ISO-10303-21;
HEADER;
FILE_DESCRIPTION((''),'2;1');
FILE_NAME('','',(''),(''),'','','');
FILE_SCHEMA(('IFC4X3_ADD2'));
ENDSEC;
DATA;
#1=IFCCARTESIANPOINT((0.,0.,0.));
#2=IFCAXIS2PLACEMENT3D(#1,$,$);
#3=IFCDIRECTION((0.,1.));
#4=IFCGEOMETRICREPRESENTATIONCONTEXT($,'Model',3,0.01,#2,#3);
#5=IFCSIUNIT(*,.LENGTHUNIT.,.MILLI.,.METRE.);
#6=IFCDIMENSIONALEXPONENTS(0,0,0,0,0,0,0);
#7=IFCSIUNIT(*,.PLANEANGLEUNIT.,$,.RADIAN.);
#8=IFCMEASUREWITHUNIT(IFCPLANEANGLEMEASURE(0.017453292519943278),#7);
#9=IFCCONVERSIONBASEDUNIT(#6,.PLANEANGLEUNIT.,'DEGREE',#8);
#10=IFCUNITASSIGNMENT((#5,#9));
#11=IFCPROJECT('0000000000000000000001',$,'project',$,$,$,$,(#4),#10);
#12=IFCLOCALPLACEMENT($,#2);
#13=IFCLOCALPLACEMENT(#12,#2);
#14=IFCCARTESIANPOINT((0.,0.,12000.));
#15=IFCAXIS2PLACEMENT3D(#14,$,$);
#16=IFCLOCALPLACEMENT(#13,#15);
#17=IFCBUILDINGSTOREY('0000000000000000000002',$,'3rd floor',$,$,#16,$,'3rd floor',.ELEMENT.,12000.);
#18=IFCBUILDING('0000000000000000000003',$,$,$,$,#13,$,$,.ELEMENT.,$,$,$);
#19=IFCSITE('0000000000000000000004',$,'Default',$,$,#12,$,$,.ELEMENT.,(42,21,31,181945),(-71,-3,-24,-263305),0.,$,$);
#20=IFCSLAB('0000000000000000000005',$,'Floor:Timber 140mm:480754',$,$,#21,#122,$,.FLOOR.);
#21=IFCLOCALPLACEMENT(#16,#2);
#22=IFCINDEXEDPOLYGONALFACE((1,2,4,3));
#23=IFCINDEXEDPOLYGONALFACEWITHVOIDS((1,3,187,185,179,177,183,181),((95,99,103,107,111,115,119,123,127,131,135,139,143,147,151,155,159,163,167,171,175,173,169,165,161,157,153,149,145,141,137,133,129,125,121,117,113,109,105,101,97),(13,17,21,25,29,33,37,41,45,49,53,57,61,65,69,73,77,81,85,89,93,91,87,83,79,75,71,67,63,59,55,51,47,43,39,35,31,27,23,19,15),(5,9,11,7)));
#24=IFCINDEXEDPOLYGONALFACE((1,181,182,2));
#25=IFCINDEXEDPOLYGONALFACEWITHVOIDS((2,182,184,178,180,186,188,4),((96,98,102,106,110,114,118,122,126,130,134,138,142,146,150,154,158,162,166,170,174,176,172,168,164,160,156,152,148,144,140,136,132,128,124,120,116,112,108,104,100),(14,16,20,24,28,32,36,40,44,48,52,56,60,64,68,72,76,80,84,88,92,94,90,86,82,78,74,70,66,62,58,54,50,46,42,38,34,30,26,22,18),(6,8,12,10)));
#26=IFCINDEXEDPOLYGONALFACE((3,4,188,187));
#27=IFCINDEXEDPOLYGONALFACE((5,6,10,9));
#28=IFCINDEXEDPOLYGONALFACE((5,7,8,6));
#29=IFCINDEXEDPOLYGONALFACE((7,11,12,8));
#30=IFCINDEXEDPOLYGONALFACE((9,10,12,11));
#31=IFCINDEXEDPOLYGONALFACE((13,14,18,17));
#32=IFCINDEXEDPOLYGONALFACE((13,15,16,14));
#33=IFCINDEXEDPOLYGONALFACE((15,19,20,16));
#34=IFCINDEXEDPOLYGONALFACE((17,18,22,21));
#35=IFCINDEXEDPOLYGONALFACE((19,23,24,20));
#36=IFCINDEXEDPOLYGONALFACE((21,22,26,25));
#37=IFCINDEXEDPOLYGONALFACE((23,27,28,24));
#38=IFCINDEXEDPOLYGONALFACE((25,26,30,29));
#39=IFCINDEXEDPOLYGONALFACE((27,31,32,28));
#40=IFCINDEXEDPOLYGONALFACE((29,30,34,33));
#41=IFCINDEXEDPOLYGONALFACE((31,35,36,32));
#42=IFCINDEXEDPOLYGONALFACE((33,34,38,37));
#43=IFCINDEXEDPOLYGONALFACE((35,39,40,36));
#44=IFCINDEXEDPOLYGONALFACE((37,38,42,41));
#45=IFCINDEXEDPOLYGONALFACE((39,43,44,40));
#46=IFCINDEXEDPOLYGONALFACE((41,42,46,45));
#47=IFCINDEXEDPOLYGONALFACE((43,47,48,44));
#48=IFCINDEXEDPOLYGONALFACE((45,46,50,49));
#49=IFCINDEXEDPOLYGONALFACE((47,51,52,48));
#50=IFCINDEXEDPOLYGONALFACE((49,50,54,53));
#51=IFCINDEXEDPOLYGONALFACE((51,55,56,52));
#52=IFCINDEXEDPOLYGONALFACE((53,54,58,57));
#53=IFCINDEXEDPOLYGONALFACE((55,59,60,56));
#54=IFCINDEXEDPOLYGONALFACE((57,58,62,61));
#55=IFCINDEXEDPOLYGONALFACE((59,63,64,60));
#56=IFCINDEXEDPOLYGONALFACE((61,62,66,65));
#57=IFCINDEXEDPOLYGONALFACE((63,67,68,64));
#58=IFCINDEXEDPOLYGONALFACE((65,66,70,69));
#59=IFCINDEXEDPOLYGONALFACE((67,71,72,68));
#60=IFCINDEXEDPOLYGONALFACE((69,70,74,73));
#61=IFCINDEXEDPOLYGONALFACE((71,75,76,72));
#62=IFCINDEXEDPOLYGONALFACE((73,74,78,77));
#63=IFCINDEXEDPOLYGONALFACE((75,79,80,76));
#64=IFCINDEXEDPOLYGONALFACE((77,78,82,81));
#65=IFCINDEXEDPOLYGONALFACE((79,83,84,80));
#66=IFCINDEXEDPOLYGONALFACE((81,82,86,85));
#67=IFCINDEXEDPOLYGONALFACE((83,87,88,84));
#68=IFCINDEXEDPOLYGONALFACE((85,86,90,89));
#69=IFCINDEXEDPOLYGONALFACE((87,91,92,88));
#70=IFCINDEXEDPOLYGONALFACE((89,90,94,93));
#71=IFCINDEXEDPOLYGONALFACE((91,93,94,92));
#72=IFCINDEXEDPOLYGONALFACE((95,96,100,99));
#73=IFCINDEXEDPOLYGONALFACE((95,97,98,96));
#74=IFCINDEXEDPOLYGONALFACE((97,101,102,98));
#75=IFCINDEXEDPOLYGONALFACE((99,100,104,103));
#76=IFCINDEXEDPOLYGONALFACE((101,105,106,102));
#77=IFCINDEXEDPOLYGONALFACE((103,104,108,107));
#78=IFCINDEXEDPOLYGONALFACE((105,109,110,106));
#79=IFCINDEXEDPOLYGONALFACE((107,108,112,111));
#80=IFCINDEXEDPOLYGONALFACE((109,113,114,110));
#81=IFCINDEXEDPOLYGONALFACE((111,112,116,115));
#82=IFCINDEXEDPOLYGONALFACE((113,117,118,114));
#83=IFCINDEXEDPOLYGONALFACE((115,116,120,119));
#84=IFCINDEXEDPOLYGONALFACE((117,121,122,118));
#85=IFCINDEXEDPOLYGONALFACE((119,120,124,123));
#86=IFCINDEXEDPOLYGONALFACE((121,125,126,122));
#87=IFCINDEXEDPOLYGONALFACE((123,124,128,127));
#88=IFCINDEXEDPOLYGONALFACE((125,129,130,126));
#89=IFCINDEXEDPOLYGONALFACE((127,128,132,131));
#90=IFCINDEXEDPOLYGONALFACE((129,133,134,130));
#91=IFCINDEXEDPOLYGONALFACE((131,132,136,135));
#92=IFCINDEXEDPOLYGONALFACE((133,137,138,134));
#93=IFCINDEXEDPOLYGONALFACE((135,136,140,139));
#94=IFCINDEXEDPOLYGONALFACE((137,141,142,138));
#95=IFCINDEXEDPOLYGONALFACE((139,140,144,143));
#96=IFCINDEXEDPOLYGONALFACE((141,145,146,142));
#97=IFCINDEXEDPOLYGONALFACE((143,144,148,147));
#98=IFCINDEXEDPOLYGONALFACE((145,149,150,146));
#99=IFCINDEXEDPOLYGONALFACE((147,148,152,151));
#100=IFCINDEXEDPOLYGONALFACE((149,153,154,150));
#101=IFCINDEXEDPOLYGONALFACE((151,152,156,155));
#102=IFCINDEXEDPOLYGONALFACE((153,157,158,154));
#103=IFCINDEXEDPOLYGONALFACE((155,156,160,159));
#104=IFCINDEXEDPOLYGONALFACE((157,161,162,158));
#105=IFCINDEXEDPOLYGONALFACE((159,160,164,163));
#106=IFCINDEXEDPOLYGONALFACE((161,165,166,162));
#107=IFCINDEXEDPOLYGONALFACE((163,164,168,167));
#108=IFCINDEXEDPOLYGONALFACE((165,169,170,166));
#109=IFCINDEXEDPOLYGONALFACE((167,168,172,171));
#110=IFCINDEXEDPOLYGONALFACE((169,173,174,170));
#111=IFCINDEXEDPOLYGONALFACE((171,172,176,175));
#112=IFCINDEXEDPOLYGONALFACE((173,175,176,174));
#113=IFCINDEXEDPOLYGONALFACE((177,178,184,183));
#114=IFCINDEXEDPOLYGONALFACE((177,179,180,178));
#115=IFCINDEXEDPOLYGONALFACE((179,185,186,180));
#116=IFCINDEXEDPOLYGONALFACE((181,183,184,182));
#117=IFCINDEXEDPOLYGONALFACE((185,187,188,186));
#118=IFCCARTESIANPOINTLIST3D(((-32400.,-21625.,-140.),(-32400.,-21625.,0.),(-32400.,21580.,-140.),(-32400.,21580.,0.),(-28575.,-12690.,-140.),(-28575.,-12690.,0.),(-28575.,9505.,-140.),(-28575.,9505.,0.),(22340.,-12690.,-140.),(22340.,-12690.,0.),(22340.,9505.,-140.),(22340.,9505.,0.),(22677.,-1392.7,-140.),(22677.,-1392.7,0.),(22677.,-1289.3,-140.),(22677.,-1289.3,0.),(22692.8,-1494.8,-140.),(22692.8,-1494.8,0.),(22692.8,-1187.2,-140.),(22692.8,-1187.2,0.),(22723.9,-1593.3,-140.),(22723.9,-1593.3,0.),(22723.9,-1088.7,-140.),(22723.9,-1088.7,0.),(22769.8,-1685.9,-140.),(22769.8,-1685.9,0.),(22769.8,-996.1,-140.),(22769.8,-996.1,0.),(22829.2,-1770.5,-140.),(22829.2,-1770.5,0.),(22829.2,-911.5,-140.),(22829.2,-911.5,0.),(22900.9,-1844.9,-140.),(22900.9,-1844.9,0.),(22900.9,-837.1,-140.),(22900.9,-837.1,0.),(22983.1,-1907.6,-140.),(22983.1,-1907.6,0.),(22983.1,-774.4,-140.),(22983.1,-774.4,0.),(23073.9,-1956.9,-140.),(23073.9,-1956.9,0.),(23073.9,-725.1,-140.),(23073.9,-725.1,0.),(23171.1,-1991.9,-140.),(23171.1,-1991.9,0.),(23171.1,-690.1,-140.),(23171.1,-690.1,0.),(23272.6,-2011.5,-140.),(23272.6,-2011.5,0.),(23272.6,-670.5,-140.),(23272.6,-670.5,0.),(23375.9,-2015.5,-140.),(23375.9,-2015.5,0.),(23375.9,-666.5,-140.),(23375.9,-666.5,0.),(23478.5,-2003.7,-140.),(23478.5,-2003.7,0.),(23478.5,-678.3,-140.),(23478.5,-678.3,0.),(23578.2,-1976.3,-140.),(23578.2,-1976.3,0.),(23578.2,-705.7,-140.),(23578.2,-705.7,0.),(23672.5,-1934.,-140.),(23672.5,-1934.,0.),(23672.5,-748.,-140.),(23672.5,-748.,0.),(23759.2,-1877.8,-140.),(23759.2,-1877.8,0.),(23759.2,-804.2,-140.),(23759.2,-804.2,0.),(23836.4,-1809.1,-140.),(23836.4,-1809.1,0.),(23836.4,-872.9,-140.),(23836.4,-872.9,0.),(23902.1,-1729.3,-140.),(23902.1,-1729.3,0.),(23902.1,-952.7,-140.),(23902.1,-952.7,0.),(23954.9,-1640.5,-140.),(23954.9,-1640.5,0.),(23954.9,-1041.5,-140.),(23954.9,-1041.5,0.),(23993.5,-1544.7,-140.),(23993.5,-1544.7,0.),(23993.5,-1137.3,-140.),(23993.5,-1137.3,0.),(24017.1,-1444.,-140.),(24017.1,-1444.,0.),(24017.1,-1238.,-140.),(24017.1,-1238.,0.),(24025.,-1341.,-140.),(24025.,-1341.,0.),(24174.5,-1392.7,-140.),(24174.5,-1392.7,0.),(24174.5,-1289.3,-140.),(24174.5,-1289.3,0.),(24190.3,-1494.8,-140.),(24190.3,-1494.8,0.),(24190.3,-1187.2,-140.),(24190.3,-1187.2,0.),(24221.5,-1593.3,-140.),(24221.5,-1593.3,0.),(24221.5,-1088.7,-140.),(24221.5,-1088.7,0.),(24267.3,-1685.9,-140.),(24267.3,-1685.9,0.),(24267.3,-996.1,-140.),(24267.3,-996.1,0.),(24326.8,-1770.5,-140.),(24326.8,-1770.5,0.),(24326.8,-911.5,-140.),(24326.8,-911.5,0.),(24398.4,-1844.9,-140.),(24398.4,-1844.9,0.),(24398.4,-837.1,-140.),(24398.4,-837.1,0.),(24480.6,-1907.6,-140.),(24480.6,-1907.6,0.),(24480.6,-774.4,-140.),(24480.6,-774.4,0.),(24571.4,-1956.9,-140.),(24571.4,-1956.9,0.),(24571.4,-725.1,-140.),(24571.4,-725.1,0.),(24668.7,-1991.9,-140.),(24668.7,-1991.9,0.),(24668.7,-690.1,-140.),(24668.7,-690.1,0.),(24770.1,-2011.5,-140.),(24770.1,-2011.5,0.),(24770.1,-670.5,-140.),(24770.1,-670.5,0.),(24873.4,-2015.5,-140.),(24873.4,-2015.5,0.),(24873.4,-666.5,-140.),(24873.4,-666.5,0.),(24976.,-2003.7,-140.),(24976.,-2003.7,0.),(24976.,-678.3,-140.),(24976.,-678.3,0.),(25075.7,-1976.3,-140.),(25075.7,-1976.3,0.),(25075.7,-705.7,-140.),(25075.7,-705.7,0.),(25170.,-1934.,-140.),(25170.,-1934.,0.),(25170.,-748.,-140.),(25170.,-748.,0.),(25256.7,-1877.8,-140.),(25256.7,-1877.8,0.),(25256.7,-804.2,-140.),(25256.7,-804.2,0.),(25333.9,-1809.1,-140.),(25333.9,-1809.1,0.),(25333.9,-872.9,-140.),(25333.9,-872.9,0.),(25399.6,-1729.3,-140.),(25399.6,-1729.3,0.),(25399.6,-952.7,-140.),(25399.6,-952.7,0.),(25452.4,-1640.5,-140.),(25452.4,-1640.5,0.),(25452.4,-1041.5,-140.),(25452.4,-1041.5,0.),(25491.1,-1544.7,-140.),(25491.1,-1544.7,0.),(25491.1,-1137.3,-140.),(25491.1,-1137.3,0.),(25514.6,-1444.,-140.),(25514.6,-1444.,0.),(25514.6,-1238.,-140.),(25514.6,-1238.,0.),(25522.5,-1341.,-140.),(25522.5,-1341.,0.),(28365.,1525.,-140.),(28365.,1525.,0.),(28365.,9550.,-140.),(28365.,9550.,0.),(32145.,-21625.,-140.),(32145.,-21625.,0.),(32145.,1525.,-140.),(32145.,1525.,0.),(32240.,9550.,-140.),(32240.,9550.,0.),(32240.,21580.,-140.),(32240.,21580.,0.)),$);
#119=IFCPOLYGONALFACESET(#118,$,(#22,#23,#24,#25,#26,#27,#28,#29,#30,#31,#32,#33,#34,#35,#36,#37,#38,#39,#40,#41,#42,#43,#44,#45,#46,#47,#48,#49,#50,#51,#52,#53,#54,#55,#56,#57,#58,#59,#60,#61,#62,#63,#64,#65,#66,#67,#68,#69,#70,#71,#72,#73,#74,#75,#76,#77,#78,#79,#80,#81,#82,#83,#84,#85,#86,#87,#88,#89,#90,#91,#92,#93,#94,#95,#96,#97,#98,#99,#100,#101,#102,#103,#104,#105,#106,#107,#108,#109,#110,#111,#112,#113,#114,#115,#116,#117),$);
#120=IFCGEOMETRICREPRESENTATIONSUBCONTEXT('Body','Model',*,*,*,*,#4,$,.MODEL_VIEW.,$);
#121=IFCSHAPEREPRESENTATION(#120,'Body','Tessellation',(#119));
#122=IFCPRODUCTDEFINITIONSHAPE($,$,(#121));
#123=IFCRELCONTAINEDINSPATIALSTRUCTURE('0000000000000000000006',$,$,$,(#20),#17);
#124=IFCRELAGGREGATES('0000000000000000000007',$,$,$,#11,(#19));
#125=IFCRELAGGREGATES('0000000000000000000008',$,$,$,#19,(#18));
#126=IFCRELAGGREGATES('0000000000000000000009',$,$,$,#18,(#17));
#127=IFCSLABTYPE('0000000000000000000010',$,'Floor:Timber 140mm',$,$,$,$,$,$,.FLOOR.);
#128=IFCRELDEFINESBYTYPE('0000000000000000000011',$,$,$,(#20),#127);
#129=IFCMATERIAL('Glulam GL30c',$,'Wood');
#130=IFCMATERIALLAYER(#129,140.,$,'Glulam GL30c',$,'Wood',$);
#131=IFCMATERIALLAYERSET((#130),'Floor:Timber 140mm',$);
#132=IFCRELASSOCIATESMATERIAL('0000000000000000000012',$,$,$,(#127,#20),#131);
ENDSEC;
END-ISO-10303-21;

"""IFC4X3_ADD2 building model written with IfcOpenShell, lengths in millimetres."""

from ifc_helpers import new_model, entity, si_unit, converted_unit, direction, frame, frame_2d, origin, place, context, subcontext, project, spatial, polyline, rectangle, circle, outline, extrude, material, layer, layer_set, layer_usage, type_object, element, save


model = new_model("IFC4X3_ADD2")

# Units and contexts
model_context = context("Model", 3, precision=0.01, world=origin(), true_north=direction((0.0, 1.0)))
body_context = subcontext(model_context, "Body", "Model", "MODEL_VIEW")
ifc_project = project(units=[si_unit("LENGTHUNIT", "METRE", prefix="MILLI"), converted_unit("PLANEANGLEUNIT", "DEGREE", entity("IfcPlaneAngleMeasure", 0.017453292519943278), si_unit("PLANEANGLEUNIT", "RADIAN"), dimensions=[0, 0, 0, 0, 0, 0, 0])], contexts=[model_context])

# Site, building, storey
site_placement = place(None, origin())
site = spatial("IfcSite", under=ifc_project, at=site_placement, Name="Default", CompositionType="ELEMENT", RefLatitude=(42, 21, 31, 181945), RefLongitude=(-71, -3, -24, -263305), RefElevation=0.0)
building_placement = place(site_placement, origin())
building = spatial("IfcBuilding", under=site, at=building_placement, CompositionType="ELEMENT")
storey_placement = place(building_placement, frame((0.0, 0.0, 12000.0)))
storey = spatial("IfcBuildingStorey", under=building, at=storey_placement, Name="3rd floor", LongName="3rd floor", CompositionType="ELEMENT", Elevation=12000.0)

# Slab, openings
ifc_material_1 = material(Name="Glulam GL30c", Category="Wood")
ifc_layer = layer(ifc_material_1, 140.0, Name="Glulam GL30c", Category="Wood")
ifc_layer_set = layer_set([ifc_layer], Name="Floor:Timber 140mm")
ifc_layer_usage = layer_usage(ifc_layer_set, "AXIS3", "POSITIVE", 0.0)
slab_type = type_object("IfcSlabType", Name="Floor:Timber 140mm", PredefinedType="FLOOR", material=ifc_layer_set)
slab_placement = place(storey_placement, frame((-32400.0, -21625.0, -140.0)))
slab = element("IfcSlab", 1, at=slab_placement, inside=storey, type_object=slab_type, material=ifc_layer_usage, Name="Floor:Timber 140mm:480754", PredefinedType="FLOOR", context=body_context, shape_type="SweptSolid", body=[
    extrude(outline(polyline([(32320.0, -21602.5), (32320.0, 21602.5), (-32320.0, 21602.5), (-32320.0, 9572.5), (-28445.0, 9572.5), (-28445.0, 1547.5), (-32225.0, 1547.5), (-32225.0, -21602.5), (32320.0, -21602.5)])), frame((32320.0, 21602.5, 140.0), z_axis=(0.0, 0.0, -1.0), x_axis=(-1.0, 0.0, 0.0)), (0.0, 0.0, 1.0), 140.0),
])
opening_1_placement = place(slab_placement, frame((32400.0, 21625.0, 140.0)))
element("IfcOpeningElement", 2, at=opening_1_placement, cuts=slab, PredefinedType="OPENING", context=body_context, shape_type="SweptSolid", body=[
    extrude(circle(Radius=675.0, at=frame_2d((0.0, 0.0), x_axis=(1.0, 0.0))), frame((23350.0, -1341.0, -400.0)), (0.0, 0.0, 1.0), 500.0),
])
opening_2_placement = place(slab_placement, frame((32400.0, 21625.0, 140.0)))
element("IfcOpeningElement", 3, at=opening_2_placement, cuts=slab, PredefinedType="OPENING", context=body_context, shape_type="SweptSolid", body=[
    extrude(circle(Radius=675.0, at=frame_2d((0.0, 0.0), x_axis=(1.0, 0.0))), frame((24847.5, -1341.0, -400.0)), (0.0, 0.0, 1.0), 500.0),
])
opening_3_placement = place(slab_placement, origin())
element("IfcOpeningElement", 4, at=opening_3_placement, cuts=slab, PredefinedType="OPENING", context=body_context, shape_type="SweptSolid", body=[
    extrude(rectangle(XDim=50915.0, YDim=22195.0, at=frame_2d((3037.5, -1570.0), x_axis=(1.0, 0.0))), frame((32320.0, 21602.5, 140.0), z_axis=(0.0, 0.0, -1.0), x_axis=(-1.0, 0.0, 0.0)), (0.0, 0.0, 1.0), 140.0),
])

save(model, "model.ifc")
